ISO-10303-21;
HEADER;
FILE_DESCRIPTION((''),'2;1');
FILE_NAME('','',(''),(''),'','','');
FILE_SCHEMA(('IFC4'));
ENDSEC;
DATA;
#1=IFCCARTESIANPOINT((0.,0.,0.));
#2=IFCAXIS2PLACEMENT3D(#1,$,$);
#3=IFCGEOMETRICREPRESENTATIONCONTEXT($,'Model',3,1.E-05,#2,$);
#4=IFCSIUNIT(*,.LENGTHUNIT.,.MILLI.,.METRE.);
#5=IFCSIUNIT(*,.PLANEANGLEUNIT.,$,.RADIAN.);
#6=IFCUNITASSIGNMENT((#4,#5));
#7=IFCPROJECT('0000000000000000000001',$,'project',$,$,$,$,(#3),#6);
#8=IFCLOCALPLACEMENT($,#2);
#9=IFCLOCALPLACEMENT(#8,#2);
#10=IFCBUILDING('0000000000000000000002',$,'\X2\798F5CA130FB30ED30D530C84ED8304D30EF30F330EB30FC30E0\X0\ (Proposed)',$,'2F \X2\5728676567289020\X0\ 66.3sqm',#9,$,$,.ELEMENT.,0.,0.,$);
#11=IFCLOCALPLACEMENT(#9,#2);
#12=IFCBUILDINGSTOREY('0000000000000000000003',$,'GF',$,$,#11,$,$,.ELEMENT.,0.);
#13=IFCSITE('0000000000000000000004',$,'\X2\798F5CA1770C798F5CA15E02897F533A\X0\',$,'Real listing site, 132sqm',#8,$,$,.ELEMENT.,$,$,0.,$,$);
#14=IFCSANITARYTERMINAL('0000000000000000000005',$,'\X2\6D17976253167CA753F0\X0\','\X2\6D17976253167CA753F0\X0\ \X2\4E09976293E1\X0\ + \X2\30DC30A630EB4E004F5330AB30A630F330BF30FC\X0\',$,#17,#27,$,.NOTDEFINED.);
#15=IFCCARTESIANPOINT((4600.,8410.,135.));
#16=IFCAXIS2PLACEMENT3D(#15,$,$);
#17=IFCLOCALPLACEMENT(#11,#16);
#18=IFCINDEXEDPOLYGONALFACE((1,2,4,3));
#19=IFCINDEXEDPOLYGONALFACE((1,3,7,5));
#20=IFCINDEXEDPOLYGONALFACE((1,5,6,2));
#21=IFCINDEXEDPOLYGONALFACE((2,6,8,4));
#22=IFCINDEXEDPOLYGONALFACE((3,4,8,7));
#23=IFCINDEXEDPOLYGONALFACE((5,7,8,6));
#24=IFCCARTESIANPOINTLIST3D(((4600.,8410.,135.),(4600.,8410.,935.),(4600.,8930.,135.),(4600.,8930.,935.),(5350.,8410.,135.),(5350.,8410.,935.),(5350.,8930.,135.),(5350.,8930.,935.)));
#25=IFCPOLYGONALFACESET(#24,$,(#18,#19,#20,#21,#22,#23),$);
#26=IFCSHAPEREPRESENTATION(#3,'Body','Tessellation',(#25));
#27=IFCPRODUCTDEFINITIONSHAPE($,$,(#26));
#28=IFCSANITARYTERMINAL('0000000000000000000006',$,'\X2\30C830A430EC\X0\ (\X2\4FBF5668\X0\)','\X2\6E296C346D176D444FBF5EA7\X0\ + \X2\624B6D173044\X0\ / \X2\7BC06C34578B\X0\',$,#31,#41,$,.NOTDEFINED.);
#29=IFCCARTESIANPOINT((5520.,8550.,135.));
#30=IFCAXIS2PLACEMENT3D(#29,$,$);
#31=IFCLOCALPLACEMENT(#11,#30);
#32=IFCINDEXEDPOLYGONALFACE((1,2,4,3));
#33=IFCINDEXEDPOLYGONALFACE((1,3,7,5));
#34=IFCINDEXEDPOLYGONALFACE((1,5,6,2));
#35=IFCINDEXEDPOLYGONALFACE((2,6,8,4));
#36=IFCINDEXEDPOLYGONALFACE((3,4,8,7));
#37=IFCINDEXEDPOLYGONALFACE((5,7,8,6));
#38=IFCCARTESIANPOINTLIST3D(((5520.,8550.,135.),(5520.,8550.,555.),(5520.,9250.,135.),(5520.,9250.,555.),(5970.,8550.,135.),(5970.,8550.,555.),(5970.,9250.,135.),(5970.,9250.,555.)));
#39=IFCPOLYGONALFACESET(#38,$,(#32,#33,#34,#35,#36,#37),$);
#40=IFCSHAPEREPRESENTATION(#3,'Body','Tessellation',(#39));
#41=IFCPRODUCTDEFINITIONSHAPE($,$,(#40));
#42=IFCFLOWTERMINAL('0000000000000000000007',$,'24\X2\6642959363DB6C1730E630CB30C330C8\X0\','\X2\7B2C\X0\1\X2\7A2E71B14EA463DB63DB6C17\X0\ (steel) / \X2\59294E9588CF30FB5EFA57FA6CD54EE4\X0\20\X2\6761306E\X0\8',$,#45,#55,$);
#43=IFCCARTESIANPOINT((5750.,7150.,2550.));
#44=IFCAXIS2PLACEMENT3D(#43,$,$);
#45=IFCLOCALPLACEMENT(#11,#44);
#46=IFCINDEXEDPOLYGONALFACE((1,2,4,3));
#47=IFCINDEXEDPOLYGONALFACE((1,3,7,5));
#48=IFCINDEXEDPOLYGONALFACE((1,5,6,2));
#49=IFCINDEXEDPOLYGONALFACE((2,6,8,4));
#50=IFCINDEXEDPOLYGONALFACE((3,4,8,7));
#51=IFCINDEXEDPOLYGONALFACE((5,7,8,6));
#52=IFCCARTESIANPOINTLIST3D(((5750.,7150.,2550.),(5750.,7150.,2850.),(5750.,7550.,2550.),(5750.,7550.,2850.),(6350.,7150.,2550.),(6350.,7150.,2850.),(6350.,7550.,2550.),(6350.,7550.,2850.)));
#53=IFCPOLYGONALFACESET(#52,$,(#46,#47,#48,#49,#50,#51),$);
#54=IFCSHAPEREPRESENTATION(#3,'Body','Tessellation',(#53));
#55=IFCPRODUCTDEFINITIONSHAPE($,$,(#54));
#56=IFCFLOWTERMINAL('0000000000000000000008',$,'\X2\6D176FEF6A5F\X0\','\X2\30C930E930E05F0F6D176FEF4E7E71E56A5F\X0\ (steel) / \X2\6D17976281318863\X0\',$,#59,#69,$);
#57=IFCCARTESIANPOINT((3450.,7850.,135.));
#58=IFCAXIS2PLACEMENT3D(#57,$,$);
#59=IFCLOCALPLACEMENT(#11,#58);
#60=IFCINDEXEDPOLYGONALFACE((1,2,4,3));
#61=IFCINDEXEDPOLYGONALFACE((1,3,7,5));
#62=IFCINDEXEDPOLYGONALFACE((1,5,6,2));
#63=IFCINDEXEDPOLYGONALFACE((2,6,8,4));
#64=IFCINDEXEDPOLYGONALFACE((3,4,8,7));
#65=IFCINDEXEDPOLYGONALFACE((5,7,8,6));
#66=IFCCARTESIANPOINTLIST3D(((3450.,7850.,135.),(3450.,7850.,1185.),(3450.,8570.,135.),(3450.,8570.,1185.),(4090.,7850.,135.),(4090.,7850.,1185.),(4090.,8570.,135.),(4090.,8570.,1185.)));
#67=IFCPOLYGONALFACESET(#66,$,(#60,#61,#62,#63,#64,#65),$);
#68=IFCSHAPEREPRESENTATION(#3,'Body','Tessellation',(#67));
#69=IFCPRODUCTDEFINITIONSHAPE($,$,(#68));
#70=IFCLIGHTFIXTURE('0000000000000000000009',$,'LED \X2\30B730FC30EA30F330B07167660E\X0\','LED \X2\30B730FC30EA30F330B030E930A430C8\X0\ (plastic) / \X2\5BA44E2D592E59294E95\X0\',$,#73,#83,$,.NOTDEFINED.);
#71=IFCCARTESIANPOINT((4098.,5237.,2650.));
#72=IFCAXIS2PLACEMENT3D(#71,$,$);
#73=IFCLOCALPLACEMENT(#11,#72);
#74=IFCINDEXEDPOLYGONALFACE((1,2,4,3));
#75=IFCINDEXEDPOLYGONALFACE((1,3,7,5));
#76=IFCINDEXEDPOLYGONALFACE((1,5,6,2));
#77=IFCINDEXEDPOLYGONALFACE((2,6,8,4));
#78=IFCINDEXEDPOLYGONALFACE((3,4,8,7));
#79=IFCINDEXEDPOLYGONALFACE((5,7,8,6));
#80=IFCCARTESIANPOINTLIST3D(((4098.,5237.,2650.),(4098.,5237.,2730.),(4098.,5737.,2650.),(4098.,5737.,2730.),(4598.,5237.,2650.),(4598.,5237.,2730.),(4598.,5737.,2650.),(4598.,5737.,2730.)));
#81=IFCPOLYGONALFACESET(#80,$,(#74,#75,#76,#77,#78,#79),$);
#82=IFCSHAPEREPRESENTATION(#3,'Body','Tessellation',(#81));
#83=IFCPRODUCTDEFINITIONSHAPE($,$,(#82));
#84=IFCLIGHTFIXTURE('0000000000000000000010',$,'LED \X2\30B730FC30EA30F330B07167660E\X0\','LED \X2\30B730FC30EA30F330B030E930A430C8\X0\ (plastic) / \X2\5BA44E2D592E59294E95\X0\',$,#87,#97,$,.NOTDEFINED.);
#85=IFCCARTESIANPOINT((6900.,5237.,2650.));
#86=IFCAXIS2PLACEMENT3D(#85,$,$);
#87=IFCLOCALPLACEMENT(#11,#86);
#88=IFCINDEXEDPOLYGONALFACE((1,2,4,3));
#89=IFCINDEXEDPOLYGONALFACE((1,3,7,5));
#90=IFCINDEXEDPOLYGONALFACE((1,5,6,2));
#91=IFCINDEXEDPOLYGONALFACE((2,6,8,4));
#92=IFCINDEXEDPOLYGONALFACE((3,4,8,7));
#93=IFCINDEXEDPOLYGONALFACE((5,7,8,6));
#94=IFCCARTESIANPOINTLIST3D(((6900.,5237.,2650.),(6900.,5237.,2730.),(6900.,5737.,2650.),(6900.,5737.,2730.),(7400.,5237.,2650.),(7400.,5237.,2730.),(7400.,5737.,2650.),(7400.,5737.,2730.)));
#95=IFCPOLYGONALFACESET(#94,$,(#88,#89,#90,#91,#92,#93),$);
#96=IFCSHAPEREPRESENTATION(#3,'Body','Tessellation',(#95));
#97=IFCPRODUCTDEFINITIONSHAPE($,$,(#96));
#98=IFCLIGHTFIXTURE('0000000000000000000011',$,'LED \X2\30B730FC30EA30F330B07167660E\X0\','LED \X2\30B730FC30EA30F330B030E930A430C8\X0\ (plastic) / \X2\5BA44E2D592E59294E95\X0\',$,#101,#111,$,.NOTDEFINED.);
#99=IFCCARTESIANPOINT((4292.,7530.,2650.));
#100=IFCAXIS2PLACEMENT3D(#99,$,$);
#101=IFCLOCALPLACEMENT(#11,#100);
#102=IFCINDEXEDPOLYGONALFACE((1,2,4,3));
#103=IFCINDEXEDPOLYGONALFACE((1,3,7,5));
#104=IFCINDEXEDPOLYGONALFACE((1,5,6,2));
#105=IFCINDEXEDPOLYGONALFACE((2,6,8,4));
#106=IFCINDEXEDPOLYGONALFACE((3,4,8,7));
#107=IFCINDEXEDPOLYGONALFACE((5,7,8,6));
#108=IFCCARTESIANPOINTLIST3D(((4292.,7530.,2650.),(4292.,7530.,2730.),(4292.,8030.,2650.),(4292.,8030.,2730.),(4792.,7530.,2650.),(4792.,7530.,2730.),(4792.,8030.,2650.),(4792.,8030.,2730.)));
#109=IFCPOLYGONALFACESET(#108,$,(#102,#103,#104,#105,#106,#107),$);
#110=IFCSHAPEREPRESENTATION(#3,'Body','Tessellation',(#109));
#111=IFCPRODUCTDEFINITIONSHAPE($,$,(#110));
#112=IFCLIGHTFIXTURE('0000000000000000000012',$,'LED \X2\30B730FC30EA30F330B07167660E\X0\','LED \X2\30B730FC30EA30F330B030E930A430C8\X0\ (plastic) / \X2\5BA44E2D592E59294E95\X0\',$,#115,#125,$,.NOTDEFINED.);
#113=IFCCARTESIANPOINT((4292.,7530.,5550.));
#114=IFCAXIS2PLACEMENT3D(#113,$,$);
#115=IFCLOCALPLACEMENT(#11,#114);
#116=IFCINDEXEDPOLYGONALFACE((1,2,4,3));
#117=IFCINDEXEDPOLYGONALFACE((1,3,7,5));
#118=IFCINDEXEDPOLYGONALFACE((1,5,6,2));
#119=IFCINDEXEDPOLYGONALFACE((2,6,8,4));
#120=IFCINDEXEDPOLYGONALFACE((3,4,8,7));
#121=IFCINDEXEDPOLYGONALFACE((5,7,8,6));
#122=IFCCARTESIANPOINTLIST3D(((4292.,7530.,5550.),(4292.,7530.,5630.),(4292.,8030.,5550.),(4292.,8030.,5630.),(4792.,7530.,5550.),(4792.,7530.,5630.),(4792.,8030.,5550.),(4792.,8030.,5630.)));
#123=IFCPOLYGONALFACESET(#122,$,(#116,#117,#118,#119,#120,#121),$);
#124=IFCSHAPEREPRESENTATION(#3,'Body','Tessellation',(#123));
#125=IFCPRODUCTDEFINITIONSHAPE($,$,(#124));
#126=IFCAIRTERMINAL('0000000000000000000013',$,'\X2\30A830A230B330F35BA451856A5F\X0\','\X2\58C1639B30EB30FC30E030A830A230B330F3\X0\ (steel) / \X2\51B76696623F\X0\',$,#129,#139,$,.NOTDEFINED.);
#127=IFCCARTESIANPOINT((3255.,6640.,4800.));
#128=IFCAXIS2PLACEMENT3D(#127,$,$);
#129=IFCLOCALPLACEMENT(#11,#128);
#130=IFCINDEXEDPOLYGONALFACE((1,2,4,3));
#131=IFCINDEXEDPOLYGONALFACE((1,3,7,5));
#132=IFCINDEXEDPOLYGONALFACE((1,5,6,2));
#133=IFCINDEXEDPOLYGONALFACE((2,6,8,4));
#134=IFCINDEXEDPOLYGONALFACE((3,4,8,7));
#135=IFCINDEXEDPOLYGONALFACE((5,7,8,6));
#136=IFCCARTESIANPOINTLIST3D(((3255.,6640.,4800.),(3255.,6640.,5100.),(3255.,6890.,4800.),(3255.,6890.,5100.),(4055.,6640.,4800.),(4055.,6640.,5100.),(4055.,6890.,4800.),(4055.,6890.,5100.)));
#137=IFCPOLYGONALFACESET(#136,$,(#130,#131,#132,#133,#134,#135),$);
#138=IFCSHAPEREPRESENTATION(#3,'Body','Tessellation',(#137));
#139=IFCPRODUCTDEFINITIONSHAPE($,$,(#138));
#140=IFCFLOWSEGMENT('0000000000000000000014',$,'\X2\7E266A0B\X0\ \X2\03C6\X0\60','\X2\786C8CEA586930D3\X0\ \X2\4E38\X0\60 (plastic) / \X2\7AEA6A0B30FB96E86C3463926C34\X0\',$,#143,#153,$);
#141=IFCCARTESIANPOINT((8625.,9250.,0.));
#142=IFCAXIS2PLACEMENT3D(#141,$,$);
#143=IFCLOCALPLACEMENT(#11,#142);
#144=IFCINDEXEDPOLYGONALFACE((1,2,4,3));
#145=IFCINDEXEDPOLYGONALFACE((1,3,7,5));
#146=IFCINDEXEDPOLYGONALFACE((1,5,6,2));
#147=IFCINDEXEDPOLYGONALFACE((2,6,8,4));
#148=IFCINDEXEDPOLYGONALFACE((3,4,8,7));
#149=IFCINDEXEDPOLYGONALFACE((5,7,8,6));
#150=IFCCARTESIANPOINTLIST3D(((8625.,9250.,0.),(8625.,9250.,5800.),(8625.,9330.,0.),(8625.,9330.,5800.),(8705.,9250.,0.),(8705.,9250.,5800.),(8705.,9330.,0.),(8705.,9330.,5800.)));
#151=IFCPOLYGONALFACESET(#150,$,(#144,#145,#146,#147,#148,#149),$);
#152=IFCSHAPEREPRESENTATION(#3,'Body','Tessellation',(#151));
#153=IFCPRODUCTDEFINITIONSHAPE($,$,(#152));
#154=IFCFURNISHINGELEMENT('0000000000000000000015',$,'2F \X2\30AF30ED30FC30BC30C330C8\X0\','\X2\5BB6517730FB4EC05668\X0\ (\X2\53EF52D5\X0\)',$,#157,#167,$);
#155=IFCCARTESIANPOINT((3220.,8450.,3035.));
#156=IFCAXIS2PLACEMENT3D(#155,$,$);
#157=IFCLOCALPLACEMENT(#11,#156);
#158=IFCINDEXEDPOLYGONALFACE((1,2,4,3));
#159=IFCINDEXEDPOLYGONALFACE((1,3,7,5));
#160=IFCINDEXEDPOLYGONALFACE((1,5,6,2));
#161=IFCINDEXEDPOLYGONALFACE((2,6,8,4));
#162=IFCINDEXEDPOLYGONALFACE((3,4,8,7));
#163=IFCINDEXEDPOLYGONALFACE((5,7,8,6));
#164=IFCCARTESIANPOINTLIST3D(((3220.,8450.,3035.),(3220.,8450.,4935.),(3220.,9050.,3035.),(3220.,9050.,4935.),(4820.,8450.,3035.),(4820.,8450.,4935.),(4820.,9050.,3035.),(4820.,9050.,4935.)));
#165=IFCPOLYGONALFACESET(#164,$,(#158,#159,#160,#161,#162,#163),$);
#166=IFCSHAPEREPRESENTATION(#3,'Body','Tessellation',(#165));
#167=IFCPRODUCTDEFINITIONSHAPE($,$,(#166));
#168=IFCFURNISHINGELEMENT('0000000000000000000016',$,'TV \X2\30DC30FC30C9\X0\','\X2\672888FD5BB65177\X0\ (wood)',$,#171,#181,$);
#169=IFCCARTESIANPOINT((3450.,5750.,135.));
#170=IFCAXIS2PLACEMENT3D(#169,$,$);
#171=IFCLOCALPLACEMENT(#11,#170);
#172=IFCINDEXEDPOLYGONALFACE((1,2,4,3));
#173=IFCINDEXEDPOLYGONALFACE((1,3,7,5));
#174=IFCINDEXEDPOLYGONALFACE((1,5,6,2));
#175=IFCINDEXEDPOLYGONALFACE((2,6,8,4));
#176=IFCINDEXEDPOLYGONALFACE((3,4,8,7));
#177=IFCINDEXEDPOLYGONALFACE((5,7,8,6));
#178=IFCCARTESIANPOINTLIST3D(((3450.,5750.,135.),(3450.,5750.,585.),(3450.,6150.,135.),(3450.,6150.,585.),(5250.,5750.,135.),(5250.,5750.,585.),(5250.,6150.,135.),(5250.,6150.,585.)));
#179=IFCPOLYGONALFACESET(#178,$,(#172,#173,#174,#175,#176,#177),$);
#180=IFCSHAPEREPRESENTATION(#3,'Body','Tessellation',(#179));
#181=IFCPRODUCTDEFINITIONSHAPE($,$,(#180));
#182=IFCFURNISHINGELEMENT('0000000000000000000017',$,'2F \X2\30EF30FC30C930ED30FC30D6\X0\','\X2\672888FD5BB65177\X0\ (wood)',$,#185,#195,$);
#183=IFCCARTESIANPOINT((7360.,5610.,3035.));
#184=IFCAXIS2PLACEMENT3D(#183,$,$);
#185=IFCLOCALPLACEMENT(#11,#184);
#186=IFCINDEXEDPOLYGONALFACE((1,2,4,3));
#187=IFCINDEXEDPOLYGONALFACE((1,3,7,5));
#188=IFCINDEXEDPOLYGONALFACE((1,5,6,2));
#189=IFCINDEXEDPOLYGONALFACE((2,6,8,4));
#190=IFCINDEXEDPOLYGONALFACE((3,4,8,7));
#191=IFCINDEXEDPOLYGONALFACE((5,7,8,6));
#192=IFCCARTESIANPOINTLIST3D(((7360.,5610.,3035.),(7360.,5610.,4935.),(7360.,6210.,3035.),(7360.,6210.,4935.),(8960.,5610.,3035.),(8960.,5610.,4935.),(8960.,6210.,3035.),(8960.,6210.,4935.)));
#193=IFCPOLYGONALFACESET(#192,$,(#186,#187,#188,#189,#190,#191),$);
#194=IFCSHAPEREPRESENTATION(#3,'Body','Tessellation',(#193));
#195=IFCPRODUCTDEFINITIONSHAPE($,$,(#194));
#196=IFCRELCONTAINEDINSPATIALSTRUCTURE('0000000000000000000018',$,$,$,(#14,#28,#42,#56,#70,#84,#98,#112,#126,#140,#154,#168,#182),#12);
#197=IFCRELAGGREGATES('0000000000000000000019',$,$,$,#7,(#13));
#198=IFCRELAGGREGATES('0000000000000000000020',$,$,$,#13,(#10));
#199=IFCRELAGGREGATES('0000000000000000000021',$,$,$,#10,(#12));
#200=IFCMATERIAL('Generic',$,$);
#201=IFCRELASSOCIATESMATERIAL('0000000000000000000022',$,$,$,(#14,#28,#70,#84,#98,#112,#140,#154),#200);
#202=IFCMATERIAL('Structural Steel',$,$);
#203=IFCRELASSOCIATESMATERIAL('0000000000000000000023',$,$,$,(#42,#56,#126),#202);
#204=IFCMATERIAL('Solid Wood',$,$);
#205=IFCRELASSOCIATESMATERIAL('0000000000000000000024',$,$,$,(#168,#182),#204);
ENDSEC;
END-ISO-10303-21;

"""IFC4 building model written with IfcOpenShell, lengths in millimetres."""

from ifc_helpers import new_model, si_unit, frame, frame_2d, origin, place, context, project, spatial, rectangle, extrude, material, element, save


model = new_model("IFC4")

# Units and contexts
model_context = context("Model", 3, precision=1e-05, world=origin())
ifc_project = project(units=[si_unit("LENGTHUNIT", "METRE", prefix="MILLI"), si_unit("PLANEANGLEUNIT", "RADIAN")], contexts=[model_context])

# Site, building, storey
site_placement = place(None, origin())
site = spatial("IfcSite", under=ifc_project, at=site_placement, Name="福岡県福岡市西区", ObjectType="Real listing site, 132sqm", CompositionType="ELEMENT", RefElevation=0.0)
building_placement = place(site_placement, origin())
building = spatial("IfcBuilding", under=site, at=building_placement, Name="福岡・ロフト付きワンルーム (Proposed)", ObjectType="2F 在来木造 66.3sqm", CompositionType="ELEMENT", ElevationOfRefHeight=0.0, ElevationOfTerrain=0.0)
storey_placement = place(building_placement, origin())
storey = spatial("IfcBuildingStorey", under=building, at=storey_placement, Name="GF", CompositionType="ELEMENT", Elevation=0.0)

# Shared definitions
ifc_material_1 = material(Name="Solid Wood")

# Sanitary terminals
ifc_material_2 = material(Name="Generic")
sanitary_terminal_1_placement = place(storey_placement, frame((4600.0, 8410.0, 135.0)))
element("IfcSanitaryTerminal", 1, at=sanitary_terminal_1_placement, inside=storey, material=ifc_material_2, Name="洗面化粧台", Description="洗面化粧台 三面鏡 + ボウル一体カウンター", PredefinedType="NOTDEFINED", context=model_context, shape_type="SweptSolid", body=[
    extrude(rectangle(XDim=750.0, YDim=520.0, at=frame_2d((375.0, 260.0))), frame((4600.0, 8410.0, 135.0)), (0.0, 0.0, 1.0), 800.0),
])
sanitary_terminal_2_placement = place(storey_placement, frame((5520.0, 8550.0, 135.0)))
element("IfcSanitaryTerminal", 2, at=sanitary_terminal_2_placement, inside=storey, material=ifc_material_2, Name="トイレ (便器)", Description="温水洗浄便座 + 手洗い / 節水型", PredefinedType="NOTDEFINED", context=model_context, shape_type="SweptSolid", body=[
    extrude(rectangle(XDim=450.0, YDim=700.0, at=frame_2d((225.0, 350.0))), frame((5520.0, 8550.0, 135.0)), (0.0, 0.0, 1.0), 420.0),
])

# Flow terminals
ifc_material_3 = material(Name="Structural Steel")
flow_terminal_1_placement = place(storey_placement, frame((5750.0, 7150.0, 2550.0)))
element("IfcFlowTerminal", 3, at=flow_terminal_1_placement, inside=storey, material=ifc_material_3, Name="24時間換気ユニット", Description="第1種熱交換換気 (steel) / 天井裏・建基法令20条の8", context=model_context, shape_type="SweptSolid", body=[
    extrude(rectangle(XDim=600.0, YDim=400.0, at=frame_2d((300.0, 200.0))), frame((5750.0, 7150.0, 2550.0)), (0.0, 0.0, 1.0), 300.0),
])
flow_terminal_2_placement = place(storey_placement, frame((3450.0, 7850.0, 135.0)))
element("IfcFlowTerminal", 4, at=flow_terminal_2_placement, inside=storey, material=ifc_material_3, Name="洗濯機", Description="ドラム式洗濯乾燥機 (steel) / 洗面脱衣", context=model_context, shape_type="SweptSolid", body=[
    extrude(rectangle(XDim=640.0, YDim=720.0, at=frame_2d((320.0, 360.0))), frame((3450.0, 7850.0, 135.0)), (0.0, 0.0, 1.0), 1050.0),
])

# Light fixtures
light_fixture_1_placement = place(storey_placement, frame((4098.0, 5237.0, 2650.0)))
element("IfcLightFixture", 5, at=light_fixture_1_placement, inside=storey, material=ifc_material_2, Name="LED シーリング照明", Description="LED シーリングライト (plastic) / 室中央天井", PredefinedType="NOTDEFINED", context=model_context, shape_type="SweptSolid", body=[
    extrude(rectangle(XDim=500.0, YDim=500.0, at=frame_2d((250.0, 250.0))), frame((4098.0, 5237.0, 2650.0)), (0.0, 0.0, 1.0), 80.0),
])
light_fixture_2_placement = place(storey_placement, frame((6900.0, 5237.0, 2650.0)))
element("IfcLightFixture", 6, at=light_fixture_2_placement, inside=storey, material=ifc_material_2, Name="LED シーリング照明", Description="LED シーリングライト (plastic) / 室中央天井", PredefinedType="NOTDEFINED", context=model_context, shape_type="SweptSolid", body=[
    extrude(rectangle(XDim=500.0, YDim=500.0, at=frame_2d((250.0, 250.0))), frame((6900.0, 5237.0, 2650.0)), (0.0, 0.0, 1.0), 80.0),
])
light_fixture_3_placement = place(storey_placement, frame((4292.0, 7530.0, 2650.0)))
element("IfcLightFixture", 7, at=light_fixture_3_placement, inside=storey, material=ifc_material_2, Name="LED シーリング照明", Description="LED シーリングライト (plastic) / 室中央天井", PredefinedType="NOTDEFINED", context=model_context, shape_type="SweptSolid", body=[
    extrude(rectangle(XDim=500.0, YDim=500.0, at=frame_2d((250.0, 250.0))), frame((4292.0, 7530.0, 2650.0)), (0.0, 0.0, 1.0), 80.0),
])
light_fixture_4_placement = place(storey_placement, frame((4292.0, 7530.0, 5550.0)))
element("IfcLightFixture", 8, at=light_fixture_4_placement, inside=storey, material=ifc_material_2, Name="LED シーリング照明", Description="LED シーリングライト (plastic) / 室中央天井", PredefinedType="NOTDEFINED", context=model_context, shape_type="SweptSolid", body=[
    extrude(rectangle(XDim=500.0, YDim=500.0, at=frame_2d((250.0, 250.0))), frame((4292.0, 7530.0, 5550.0)), (0.0, 0.0, 1.0), 80.0),
])

# Air terminal
air_terminal_placement = place(storey_placement, frame((3255.0, 6640.0, 4800.0)))
element("IfcAirTerminal", 9, at=air_terminal_placement, inside=storey, material=ifc_material_3, Name="エアコン室内機", Description="壁掛ルームエアコン (steel) / 冷暖房", PredefinedType="NOTDEFINED", context=model_context, shape_type="SweptSolid", body=[
    extrude(rectangle(XDim=800.0, YDim=250.0, at=frame_2d((400.0, 125.0))), frame((3255.0, 6640.0, 4800.0)), (0.0, 0.0, 1.0), 300.0),
])

# Flow segment
flow_segment_placement = place(storey_placement, frame((8625.0, 9250.0, 0.0)))
element("IfcFlowSegment", 10, at=flow_segment_placement, inside=storey, material=ifc_material_2, Name="縦樋 φ60", Description="硬質塩ビ 丸60 (plastic) / 竪樋・雨水排水", context=model_context, shape_type="SweptSolid", body=[
    extrude(rectangle(XDim=80.0, YDim=80.0, at=frame_2d((40.0, 40.0))), frame((8625.0, 9250.0, 0.0)), (0.0, 0.0, 1.0), 5800.0),
])

# Furnishing elements
furnishing_1_placement = place(storey_placement, frame((3220.0, 8450.0, 3035.0)))
element("IfcFurnishingElement", 11, at=furnishing_1_placement, inside=storey, material=ifc_material_2, Name="2F クローゼット", Description="家具・什器 (可動)", context=model_context, shape_type="SweptSolid", body=[
    extrude(rectangle(XDim=1600.0, YDim=600.0, at=frame_2d((800.0, 300.0))), frame((3220.0, 8450.0, 3035.0)), (0.0, 0.0, 1.0), 1900.0),
])
furnishing_2_placement = place(storey_placement, frame((3450.0, 5750.0, 135.0)))
element("IfcFurnishingElement", 12, at=furnishing_2_placement, inside=storey, material=ifc_material_1, Name="TV ボード", Description="木製家具 (wood)", context=model_context, shape_type="SweptSolid", body=[
    extrude(rectangle(XDim=1800.0, YDim=400.0, at=frame_2d((900.0, 200.0))), frame((3450.0, 5750.0, 135.0)), (0.0, 0.0, 1.0), 450.0),
])
furnishing_3_placement = place(storey_placement, frame((7360.0, 5610.0, 3035.0)))
element("IfcFurnishingElement", 13, at=furnishing_3_placement, inside=storey, material=ifc_material_1, Name="2F ワードローブ", Description="木製家具 (wood)", context=model_context, shape_type="SweptSolid", body=[
    extrude(rectangle(XDim=1600.0, YDim=600.0, at=frame_2d((800.0, 300.0))), frame((7360.0, 5610.0, 3035.0)), (0.0, 0.0, 1.0), 1900.0),
])

save(model, "model.ifc")
